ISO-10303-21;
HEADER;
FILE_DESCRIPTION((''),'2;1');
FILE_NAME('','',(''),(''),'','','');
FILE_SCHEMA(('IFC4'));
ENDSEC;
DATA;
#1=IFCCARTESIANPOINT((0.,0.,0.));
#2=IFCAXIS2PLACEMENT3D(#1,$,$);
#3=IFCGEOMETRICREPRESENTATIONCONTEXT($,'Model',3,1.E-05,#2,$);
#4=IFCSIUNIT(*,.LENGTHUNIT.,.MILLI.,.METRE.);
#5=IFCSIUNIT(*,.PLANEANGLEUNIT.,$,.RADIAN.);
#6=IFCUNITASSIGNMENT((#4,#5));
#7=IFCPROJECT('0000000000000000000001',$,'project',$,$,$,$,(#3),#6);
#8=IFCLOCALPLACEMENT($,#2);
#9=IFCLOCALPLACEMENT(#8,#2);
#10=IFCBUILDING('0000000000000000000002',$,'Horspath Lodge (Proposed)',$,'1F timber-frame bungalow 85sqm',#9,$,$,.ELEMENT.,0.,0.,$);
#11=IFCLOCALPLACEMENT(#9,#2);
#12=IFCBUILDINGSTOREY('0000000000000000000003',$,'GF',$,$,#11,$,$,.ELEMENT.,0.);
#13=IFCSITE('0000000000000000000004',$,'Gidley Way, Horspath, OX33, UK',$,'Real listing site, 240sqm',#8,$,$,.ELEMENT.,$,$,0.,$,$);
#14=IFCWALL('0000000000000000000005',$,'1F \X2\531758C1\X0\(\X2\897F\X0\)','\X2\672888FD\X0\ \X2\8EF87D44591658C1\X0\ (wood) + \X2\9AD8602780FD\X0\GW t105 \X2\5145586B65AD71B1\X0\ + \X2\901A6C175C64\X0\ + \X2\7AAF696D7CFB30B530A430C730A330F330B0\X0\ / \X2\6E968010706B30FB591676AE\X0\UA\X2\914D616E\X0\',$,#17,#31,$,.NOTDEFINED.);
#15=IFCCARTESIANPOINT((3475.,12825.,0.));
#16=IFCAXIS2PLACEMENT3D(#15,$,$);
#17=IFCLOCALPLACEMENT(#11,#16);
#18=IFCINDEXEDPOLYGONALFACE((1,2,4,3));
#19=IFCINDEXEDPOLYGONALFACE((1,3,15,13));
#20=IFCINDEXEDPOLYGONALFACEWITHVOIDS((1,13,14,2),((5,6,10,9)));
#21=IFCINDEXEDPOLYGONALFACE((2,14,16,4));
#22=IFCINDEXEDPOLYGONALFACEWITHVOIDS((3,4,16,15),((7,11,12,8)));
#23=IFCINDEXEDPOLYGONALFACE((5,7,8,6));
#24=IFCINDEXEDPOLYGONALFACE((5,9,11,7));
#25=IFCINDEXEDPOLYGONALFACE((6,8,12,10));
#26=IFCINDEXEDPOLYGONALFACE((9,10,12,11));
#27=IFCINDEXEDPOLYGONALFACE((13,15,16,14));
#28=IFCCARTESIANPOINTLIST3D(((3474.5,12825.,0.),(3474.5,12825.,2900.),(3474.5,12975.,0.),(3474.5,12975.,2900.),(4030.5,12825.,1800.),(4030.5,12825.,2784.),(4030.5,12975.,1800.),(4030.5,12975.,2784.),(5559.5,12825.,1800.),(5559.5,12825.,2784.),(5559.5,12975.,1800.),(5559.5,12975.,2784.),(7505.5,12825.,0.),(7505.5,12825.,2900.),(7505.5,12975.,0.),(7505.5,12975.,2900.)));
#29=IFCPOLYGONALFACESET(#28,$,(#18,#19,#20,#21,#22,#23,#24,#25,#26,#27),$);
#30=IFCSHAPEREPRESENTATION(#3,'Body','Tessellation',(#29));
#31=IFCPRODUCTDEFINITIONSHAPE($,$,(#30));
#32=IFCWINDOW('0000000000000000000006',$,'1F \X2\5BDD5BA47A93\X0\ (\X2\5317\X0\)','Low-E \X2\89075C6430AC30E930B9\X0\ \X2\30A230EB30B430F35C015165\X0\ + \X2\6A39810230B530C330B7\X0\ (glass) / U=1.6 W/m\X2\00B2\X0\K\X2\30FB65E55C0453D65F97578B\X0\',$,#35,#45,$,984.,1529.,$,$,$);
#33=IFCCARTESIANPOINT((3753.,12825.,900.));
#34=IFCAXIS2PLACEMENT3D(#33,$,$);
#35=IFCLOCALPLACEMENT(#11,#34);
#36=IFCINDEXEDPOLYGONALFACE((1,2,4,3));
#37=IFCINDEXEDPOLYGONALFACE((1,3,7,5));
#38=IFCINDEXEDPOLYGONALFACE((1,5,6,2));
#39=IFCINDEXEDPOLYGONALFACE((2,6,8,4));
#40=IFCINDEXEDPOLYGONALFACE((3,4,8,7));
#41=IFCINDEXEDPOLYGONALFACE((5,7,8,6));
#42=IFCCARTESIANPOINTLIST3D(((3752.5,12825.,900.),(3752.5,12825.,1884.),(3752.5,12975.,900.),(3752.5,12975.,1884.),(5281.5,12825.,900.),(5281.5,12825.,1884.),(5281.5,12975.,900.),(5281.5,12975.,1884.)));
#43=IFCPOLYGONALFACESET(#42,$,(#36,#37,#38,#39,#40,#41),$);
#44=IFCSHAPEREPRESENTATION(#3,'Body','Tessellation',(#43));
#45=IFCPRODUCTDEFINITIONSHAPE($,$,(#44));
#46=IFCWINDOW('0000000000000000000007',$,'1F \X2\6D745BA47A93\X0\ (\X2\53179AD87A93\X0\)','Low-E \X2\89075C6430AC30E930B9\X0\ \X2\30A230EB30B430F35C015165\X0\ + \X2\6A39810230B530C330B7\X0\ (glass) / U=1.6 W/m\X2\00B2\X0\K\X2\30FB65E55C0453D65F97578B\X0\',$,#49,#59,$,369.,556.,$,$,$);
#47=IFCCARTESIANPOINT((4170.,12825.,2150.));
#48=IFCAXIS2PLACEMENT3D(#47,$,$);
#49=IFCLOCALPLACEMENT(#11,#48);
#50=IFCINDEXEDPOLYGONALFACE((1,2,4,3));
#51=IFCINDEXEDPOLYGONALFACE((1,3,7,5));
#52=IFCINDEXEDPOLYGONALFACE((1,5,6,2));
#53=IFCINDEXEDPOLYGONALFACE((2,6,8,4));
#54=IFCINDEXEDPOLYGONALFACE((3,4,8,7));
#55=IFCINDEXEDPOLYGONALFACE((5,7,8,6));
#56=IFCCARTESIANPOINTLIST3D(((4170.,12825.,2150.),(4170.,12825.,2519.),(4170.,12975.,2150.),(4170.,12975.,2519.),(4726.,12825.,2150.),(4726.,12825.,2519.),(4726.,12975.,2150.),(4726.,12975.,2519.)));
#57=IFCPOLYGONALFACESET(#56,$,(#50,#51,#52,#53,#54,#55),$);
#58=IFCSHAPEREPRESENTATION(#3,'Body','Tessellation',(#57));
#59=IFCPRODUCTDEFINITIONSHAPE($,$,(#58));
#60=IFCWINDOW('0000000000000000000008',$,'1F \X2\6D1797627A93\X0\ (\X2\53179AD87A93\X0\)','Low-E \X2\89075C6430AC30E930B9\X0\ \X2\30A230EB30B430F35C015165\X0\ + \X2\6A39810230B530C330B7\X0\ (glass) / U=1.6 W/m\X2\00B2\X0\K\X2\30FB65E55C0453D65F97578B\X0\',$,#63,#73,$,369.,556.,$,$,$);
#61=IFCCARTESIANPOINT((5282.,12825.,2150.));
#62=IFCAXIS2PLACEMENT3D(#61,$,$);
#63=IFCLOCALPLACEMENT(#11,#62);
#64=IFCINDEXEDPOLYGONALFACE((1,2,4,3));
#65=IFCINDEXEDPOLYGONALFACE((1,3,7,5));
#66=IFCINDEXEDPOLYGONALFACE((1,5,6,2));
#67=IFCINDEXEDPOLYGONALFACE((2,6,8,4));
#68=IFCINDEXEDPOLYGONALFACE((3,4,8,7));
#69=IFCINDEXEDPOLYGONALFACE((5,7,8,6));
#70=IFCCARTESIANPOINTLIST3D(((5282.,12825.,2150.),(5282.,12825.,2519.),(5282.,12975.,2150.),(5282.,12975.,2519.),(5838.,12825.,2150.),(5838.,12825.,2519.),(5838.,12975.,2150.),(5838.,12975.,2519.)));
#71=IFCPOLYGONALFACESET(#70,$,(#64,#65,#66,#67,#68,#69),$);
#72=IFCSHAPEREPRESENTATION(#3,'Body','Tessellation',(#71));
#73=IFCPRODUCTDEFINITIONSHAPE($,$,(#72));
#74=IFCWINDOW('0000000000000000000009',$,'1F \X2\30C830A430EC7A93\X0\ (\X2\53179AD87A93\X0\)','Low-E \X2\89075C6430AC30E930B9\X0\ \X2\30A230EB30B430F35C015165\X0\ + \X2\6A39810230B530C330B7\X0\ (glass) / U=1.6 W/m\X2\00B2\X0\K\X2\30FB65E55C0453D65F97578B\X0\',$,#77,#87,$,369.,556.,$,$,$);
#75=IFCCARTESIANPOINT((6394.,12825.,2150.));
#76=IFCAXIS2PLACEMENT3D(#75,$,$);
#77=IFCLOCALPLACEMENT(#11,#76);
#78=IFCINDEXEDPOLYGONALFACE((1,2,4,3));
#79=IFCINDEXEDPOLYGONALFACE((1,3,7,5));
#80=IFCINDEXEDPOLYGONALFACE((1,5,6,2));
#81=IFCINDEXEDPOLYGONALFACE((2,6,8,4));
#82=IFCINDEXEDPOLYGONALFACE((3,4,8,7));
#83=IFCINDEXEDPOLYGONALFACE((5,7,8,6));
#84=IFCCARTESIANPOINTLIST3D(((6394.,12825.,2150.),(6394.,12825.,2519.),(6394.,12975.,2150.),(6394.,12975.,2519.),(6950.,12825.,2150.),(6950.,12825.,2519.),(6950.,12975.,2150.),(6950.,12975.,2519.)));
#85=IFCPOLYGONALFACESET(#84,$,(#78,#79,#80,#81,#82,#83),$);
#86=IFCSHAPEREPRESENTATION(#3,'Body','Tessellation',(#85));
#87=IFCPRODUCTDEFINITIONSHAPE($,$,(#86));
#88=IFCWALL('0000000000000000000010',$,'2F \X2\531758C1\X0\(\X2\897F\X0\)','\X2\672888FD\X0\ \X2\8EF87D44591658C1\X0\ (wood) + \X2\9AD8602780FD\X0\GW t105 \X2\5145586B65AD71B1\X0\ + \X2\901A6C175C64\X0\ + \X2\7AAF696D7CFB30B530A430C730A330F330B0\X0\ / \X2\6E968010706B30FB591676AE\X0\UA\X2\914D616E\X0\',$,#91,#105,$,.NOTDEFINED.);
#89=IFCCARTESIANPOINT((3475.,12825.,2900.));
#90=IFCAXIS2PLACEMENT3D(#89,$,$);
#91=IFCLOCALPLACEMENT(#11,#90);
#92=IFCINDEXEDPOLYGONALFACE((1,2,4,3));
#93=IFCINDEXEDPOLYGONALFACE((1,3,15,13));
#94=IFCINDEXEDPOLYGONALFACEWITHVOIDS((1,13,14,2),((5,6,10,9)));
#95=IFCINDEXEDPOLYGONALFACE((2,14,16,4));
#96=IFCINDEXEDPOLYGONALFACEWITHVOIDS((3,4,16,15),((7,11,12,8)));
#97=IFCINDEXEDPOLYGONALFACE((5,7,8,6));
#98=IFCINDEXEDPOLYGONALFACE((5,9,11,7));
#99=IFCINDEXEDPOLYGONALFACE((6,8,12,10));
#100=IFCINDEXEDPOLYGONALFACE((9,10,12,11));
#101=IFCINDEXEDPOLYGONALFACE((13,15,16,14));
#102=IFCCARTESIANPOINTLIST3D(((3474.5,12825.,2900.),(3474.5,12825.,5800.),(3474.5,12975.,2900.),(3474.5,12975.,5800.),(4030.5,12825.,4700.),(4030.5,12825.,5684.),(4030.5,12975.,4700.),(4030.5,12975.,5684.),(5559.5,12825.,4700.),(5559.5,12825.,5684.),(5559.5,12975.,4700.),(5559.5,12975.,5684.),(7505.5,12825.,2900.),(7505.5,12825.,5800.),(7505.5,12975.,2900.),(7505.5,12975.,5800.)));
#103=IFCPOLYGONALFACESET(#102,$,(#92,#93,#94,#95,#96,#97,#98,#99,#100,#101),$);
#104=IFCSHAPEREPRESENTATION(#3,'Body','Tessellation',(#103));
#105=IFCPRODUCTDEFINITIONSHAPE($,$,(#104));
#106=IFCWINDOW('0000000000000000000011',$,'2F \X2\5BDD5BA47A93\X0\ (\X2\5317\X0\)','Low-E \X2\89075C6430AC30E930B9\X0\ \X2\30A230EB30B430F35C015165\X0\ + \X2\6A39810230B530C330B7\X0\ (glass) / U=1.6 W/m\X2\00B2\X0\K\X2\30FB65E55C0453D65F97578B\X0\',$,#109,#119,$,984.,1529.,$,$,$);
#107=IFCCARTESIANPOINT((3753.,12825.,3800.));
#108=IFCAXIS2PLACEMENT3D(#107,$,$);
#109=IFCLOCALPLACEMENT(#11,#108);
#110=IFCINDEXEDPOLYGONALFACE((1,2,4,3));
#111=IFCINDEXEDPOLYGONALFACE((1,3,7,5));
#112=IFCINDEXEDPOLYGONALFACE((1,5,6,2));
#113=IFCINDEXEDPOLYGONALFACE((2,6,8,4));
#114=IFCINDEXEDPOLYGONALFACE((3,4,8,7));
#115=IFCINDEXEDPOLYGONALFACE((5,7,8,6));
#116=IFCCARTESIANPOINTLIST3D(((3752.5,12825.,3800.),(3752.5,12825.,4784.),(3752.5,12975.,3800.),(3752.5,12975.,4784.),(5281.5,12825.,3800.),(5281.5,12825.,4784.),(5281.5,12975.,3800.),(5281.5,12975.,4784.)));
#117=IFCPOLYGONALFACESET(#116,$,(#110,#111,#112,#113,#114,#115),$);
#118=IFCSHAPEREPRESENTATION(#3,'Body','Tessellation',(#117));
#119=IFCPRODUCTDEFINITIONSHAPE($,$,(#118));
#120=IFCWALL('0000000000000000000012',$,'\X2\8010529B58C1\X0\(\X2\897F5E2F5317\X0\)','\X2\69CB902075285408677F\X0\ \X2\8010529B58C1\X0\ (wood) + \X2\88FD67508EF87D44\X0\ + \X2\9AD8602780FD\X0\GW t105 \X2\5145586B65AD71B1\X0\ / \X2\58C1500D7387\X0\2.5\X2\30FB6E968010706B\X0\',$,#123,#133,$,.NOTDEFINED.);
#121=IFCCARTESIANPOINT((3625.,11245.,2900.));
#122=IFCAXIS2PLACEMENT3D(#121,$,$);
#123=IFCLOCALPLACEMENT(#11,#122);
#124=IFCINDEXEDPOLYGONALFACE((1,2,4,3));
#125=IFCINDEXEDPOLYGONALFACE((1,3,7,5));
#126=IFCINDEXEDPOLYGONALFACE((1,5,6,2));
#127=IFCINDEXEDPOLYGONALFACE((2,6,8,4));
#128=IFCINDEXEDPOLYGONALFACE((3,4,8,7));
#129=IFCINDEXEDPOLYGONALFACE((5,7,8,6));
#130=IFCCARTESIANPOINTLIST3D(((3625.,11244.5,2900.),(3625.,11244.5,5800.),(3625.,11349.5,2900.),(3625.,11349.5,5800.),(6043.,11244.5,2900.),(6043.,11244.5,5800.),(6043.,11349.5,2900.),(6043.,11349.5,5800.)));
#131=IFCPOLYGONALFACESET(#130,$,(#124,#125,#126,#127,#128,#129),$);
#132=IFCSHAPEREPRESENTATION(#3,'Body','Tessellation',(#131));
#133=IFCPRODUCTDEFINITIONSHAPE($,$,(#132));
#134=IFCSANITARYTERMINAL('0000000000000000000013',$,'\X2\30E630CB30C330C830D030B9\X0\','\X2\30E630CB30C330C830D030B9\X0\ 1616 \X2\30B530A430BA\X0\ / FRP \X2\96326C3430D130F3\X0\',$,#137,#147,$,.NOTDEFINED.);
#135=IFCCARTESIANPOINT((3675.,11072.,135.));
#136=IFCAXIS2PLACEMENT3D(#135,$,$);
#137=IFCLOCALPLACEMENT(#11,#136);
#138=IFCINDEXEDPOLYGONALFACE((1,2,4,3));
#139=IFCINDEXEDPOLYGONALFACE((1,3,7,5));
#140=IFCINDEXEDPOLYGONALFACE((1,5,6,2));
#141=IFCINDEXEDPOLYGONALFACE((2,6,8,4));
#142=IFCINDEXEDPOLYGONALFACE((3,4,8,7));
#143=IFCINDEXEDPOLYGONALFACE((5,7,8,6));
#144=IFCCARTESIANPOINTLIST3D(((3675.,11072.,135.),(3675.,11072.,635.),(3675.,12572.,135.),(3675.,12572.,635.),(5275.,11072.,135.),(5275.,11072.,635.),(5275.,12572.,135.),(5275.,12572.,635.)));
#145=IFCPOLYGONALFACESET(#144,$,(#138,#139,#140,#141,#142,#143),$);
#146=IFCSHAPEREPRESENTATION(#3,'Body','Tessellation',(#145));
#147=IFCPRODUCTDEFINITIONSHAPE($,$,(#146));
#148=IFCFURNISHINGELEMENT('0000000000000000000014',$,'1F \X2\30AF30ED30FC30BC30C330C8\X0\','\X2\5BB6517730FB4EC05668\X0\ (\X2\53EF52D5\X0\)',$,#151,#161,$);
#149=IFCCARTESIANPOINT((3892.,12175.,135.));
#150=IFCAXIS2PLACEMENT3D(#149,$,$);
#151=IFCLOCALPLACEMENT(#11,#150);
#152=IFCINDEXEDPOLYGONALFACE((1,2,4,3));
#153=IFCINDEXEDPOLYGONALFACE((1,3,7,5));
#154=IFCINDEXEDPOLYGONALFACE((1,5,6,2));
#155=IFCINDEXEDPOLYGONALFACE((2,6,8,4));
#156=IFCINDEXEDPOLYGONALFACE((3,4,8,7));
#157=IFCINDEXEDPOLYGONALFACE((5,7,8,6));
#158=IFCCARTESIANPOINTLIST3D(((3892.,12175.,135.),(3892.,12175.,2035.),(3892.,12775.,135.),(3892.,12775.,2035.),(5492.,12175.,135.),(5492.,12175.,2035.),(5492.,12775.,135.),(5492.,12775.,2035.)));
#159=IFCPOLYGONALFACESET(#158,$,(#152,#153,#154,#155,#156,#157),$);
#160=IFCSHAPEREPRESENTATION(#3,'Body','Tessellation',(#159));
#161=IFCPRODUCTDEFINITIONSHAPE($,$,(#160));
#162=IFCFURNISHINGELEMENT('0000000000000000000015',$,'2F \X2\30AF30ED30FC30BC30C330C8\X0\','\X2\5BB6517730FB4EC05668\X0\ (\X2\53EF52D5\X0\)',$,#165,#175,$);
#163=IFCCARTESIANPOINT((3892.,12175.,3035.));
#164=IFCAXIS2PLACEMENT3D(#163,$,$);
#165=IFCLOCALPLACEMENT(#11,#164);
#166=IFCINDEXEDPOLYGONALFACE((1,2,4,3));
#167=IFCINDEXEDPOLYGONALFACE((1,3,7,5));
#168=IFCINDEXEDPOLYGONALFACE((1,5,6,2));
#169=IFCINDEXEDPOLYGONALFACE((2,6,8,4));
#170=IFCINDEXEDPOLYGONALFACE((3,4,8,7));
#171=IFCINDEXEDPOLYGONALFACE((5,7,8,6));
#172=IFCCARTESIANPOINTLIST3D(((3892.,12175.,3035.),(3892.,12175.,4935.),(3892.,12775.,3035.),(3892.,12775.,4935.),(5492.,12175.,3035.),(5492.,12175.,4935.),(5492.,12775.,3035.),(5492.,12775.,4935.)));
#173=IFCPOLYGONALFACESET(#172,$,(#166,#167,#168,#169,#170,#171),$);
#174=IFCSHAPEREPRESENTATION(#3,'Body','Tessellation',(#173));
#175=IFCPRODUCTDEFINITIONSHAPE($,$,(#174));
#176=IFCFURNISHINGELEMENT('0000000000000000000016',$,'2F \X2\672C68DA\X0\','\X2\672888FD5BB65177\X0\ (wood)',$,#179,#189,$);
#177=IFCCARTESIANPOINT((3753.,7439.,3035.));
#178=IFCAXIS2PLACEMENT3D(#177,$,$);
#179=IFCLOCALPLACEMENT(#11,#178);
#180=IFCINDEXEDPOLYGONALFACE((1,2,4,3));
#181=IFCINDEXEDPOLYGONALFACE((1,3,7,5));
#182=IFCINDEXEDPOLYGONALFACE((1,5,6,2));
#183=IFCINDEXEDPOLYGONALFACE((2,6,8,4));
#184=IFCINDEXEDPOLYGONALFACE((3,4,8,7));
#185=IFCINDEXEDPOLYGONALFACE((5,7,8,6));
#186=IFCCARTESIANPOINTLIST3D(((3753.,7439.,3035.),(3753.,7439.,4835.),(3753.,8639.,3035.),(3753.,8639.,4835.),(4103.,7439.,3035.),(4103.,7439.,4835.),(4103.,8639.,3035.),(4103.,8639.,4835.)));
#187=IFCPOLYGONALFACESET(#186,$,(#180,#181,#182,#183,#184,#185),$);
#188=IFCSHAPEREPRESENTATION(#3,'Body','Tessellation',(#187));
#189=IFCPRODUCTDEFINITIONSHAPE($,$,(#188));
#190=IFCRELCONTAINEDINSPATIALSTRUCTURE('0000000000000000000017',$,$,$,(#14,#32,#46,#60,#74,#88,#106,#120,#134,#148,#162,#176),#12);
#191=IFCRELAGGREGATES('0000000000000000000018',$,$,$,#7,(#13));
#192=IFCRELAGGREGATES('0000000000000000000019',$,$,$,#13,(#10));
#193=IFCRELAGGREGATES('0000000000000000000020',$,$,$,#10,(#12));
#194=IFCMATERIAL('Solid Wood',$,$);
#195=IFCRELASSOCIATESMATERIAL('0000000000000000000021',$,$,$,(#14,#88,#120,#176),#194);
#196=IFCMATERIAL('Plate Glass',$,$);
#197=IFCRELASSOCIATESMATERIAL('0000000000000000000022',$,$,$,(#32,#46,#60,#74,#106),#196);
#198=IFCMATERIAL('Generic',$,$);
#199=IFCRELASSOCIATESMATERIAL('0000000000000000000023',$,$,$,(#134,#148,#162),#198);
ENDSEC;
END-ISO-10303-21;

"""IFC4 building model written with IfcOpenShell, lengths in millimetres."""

from ifc_helpers import new_model, si_unit, frame, frame_2d, origin, place, context, project, spatial, rectangle, extrude, material, element, fill, save


model = new_model("IFC4")

# Units and contexts
model_context = context("Model", 3, precision=1e-05, world=origin())
ifc_project = project(units=[si_unit("LENGTHUNIT", "METRE", prefix="MILLI"), si_unit("PLANEANGLEUNIT", "RADIAN")], contexts=[model_context])

# Site, building, storey
site_placement = place(None, origin())
site = spatial("IfcSite", under=ifc_project, at=site_placement, Name="Gidley Way, Horspath, OX33, UK", ObjectType="Real listing site, 240sqm", CompositionType="ELEMENT", RefElevation=0.0)
building_placement = place(site_placement, origin())
building = spatial("IfcBuilding", under=site, at=building_placement, Name="Horspath Lodge (Proposed)", ObjectType="1F timber-frame bungalow 85sqm", CompositionType="ELEMENT", ElevationOfRefHeight=0.0, ElevationOfTerrain=0.0)
storey_placement = place(building_placement, origin())
storey = spatial("IfcBuildingStorey", under=building, at=storey_placement, Name="GF", CompositionType="ELEMENT", Elevation=0.0)

# Shared definitions
ifc_material_1 = material(Name="Solid Wood")

# Wall, openings, windows
wall_1_placement = place(storey_placement, frame((3475.0, 12825.0, 0.0)))
wall_1 = element("IfcWall", 1, at=wall_1_placement, inside=storey, material=ifc_material_1, Name="1F 北壁(西)", Description="木製 軸組外壁 (wood) + 高性能GW t105 充填断熱 + 通気層 + 窯業系サイディング / 準耐火・外皮UA配慮", PredefinedType="NOTDEFINED", context=model_context, shape_type="SweptSolid", body=[
    extrude(rectangle(XDim=4031.0, YDim=150.0, at=frame_2d((2015.0, 75.0))), frame((3475.0, 12825.0, 0.0)), (0.0, 0.0, 1.0), 2900.0),
])
opening_1_placement = place(storey_placement, frame((3753.0, 12825.0, 900.0)))
opening_1 = element("IfcOpeningElement", 2, at=opening_1_placement, cuts=wall_1, PredefinedType="NOTDEFINED", context=model_context, shape_type="SweptSolid", body=[
    extrude(rectangle(XDim=1529.0, YDim=150.0, at=frame_2d((764.0, 75.0))), frame((3753.0, 12825.0, 900.0)), (0.0, 0.0, 1.0), 984.0),
])
opening_2_placement = place(storey_placement, frame((4170.0, 12825.0, 2150.0)))
opening_2 = element("IfcOpeningElement", 3, at=opening_2_placement, cuts=wall_1, PredefinedType="NOTDEFINED", context=model_context, shape_type="SweptSolid", body=[
    extrude(rectangle(XDim=556.0, YDim=150.0, at=frame_2d((278.0, 75.0))), frame((4170.0, 12825.0, 2150.0)), (0.0, 0.0, 1.0), 369.0),
])
opening_3_placement = place(storey_placement, frame((5282.0, 12825.0, 2150.0)))
opening_3 = element("IfcOpeningElement", 4, at=opening_3_placement, cuts=wall_1, PredefinedType="NOTDEFINED", context=model_context, shape_type="SweptSolid", body=[
    extrude(rectangle(XDim=556.0, YDim=150.0, at=frame_2d((278.0, 75.0))), frame((5282.0, 12825.0, 2150.0)), (0.0, 0.0, 1.0), 369.0),
])
opening_4_placement = place(storey_placement, frame((6394.0, 12825.0, 2150.0)))
opening_4 = element("IfcOpeningElement", 5, at=opening_4_placement, cuts=wall_1, PredefinedType="NOTDEFINED", context=model_context, shape_type="SweptSolid", body=[
    extrude(rectangle(XDim=556.0, YDim=150.0, at=frame_2d((278.0, 75.0))), frame((6394.0, 12825.0, 2150.0)), (0.0, 0.0, 1.0), 369.0),
])
ifc_material_2 = material(Name="Plate Glass")
window_1_placement = place(storey_placement, frame((3753.0, 12825.0, 900.0)))
window_1 = element("IfcWindow", 6, at=window_1_placement, inside=storey, material=ifc_material_2, Name="1F 寝室窓 (北)", Description="Low-E 複層ガラス アルゴン封入 + 樹脂サッシ (glass) / U=1.6 W/m²K・日射取得型", OverallHeight=984.0, OverallWidth=1529.0, context=model_context, shape_type="SweptSolid", body=[
    extrude(rectangle(XDim=1529.0, YDim=150.0, at=frame_2d((764.0, 75.0))), frame((3753.0, 12825.0, 900.0)), (0.0, 0.0, 1.0), 984.0),
])
fill(opening_1, window_1)
window_2_placement = place(storey_placement, frame((4170.0, 12825.0, 2150.0)))
window_2 = element("IfcWindow", 7, at=window_2_placement, inside=storey, material=ifc_material_2, Name="1F 浴室窓 (北高窓)", Description="Low-E 複層ガラス アルゴン封入 + 樹脂サッシ (glass) / U=1.6 W/m²K・日射取得型", OverallHeight=369.0, OverallWidth=556.0, context=model_context, shape_type="SweptSolid", body=[
    extrude(rectangle(XDim=556.0, YDim=150.0, at=frame_2d((278.0, 75.0))), frame((4170.0, 12825.0, 2150.0)), (0.0, 0.0, 1.0), 369.0),
])
fill(opening_2, window_2)
window_3_placement = place(storey_placement, frame((5282.0, 12825.0, 2150.0)))
window_3 = element("IfcWindow", 8, at=window_3_placement, inside=storey, material=ifc_material_2, Name="1F 洗面窓 (北高窓)", Description="Low-E 複層ガラス アルゴン封入 + 樹脂サッシ (glass) / U=1.6 W/m²K・日射取得型", OverallHeight=369.0, OverallWidth=556.0, context=model_context, shape_type="SweptSolid", body=[
    extrude(rectangle(XDim=556.0, YDim=150.0, at=frame_2d((278.0, 75.0))), frame((5282.0, 12825.0, 2150.0)), (0.0, 0.0, 1.0), 369.0),
])
fill(opening_3, window_3)
window_4_placement = place(storey_placement, frame((6394.0, 12825.0, 2150.0)))
window_4 = element("IfcWindow", 9, at=window_4_placement, inside=storey, material=ifc_material_2, Name="1F トイレ窓 (北高窓)", Description="Low-E 複層ガラス アルゴン封入 + 樹脂サッシ (glass) / U=1.6 W/m²K・日射取得型", OverallHeight=369.0, OverallWidth=556.0, context=model_context, shape_type="SweptSolid", body=[
    extrude(rectangle(XDim=556.0, YDim=150.0, at=frame_2d((278.0, 75.0))), frame((6394.0, 12825.0, 2150.0)), (0.0, 0.0, 1.0), 369.0),
])
fill(opening_4, window_4)

# Wall, opening, window
wall_2_placement = place(storey_placement, frame((3475.0, 12825.0, 2900.0)))
wall_2 = element("IfcWall", 10, at=wall_2_placement, inside=storey, material=ifc_material_1, Name="2F 北壁(西)", Description="木製 軸組外壁 (wood) + 高性能GW t105 充填断熱 + 通気層 + 窯業系サイディング / 準耐火・外皮UA配慮", PredefinedType="NOTDEFINED", context=model_context, shape_type="SweptSolid", body=[
    extrude(rectangle(XDim=4031.0, YDim=150.0, at=frame_2d((2015.0, 75.0))), frame((3475.0, 12825.0, 2900.0)), (0.0, 0.0, 1.0), 2900.0),
])
opening_5_placement = place(storey_placement, frame((3753.0, 12825.0, 3800.0)))
opening_5 = element("IfcOpeningElement", 11, at=opening_5_placement, cuts=wall_2, PredefinedType="NOTDEFINED", context=model_context, shape_type="SweptSolid", body=[
    extrude(rectangle(XDim=1529.0, YDim=150.0, at=frame_2d((764.0, 75.0))), frame((3753.0, 12825.0, 3800.0)), (0.0, 0.0, 1.0), 984.0),
])
window_5_placement = place(storey_placement, frame((3753.0, 12825.0, 3800.0)))
window_5 = element("IfcWindow", 12, at=window_5_placement, inside=storey, material=ifc_material_2, Name="2F 寝室窓 (北)", Description="Low-E 複層ガラス アルゴン封入 + 樹脂サッシ (glass) / U=1.6 W/m²K・日射取得型", OverallHeight=984.0, OverallWidth=1529.0, context=model_context, shape_type="SweptSolid", body=[
    extrude(rectangle(XDim=1529.0, YDim=150.0, at=frame_2d((764.0, 75.0))), frame((3753.0, 12825.0, 3800.0)), (0.0, 0.0, 1.0), 984.0),
])
fill(opening_5, window_5)

# Wall
wall_3_placement = place(storey_placement, frame((3625.0, 11245.0, 2900.0)))
element("IfcWall", 13, at=wall_3_placement, inside=storey, material=ifc_material_1, Name="耐力壁(西帯北)", Description="構造用合板 耐力壁 (wood) + 製材軸組 + 高性能GW t105 充填断熱 / 壁倍率2.5・準耐火", PredefinedType="NOTDEFINED", context=model_context, shape_type="SweptSolid", body=[
    extrude(rectangle(XDim=2418.0, YDim=105.0, at=frame_2d((1209.0, 52.0))), frame((3625.0, 11245.0, 2900.0)), (0.0, 0.0, 1.0), 2900.0),
])

# Shared definitions
ifc_material_3 = material(Name="Generic")

# Sanitary terminal
sanitary_terminal_placement = place(storey_placement, frame((3675.0, 11072.0, 135.0)))
element("IfcSanitaryTerminal", 14, at=sanitary_terminal_placement, inside=storey, material=ifc_material_3, Name="ユニットバス", Description="ユニットバス 1616 サイズ / FRP 防水パン", PredefinedType="NOTDEFINED", context=model_context, shape_type="SweptSolid", body=[
    extrude(rectangle(XDim=1600.0, YDim=1500.0, at=frame_2d((800.0, 750.0))), frame((3675.0, 11072.0, 135.0)), (0.0, 0.0, 1.0), 500.0),
])

# Furnishing elements
furnishing_1_placement = place(storey_placement, frame((3892.0, 12175.0, 135.0)))
element("IfcFurnishingElement", 15, at=furnishing_1_placement, inside=storey, material=ifc_material_3, Name="1F クローゼット", Description="家具・什器 (可動)", context=model_context, shape_type="SweptSolid", body=[
    extrude(rectangle(XDim=1600.0, YDim=600.0, at=frame_2d((800.0, 300.0))), frame((3892.0, 12175.0, 135.0)), (0.0, 0.0, 1.0), 1900.0),
])
furnishing_2_placement = place(storey_placement, frame((3892.0, 12175.0, 3035.0)))
element("IfcFurnishingElement", 16, at=furnishing_2_placement, inside=storey, material=ifc_material_3, Name="2F クローゼット", Description="家具・什器 (可動)", context=model_context, shape_type="SweptSolid", body=[
    extrude(rectangle(XDim=1600.0, YDim=600.0, at=frame_2d((800.0, 300.0))), frame((3892.0, 12175.0, 3035.0)), (0.0, 0.0, 1.0), 1900.0),
])
furnishing_3_placement = place(storey_placement, frame((3753.0, 7439.0, 3035.0)))
element("IfcFurnishingElement", 17, at=furnishing_3_placement, inside=storey, material=ifc_material_1, Name="2F 本棚", Description="木製家具 (wood)", context=model_context, shape_type="SweptSolid", body=[
    extrude(rectangle(XDim=350.0, YDim=1200.0, at=frame_2d((175.0, 600.0))), frame((3753.0, 7439.0, 3035.0)), (0.0, 0.0, 1.0), 1800.0),
])

save(model, "model.ifc")
